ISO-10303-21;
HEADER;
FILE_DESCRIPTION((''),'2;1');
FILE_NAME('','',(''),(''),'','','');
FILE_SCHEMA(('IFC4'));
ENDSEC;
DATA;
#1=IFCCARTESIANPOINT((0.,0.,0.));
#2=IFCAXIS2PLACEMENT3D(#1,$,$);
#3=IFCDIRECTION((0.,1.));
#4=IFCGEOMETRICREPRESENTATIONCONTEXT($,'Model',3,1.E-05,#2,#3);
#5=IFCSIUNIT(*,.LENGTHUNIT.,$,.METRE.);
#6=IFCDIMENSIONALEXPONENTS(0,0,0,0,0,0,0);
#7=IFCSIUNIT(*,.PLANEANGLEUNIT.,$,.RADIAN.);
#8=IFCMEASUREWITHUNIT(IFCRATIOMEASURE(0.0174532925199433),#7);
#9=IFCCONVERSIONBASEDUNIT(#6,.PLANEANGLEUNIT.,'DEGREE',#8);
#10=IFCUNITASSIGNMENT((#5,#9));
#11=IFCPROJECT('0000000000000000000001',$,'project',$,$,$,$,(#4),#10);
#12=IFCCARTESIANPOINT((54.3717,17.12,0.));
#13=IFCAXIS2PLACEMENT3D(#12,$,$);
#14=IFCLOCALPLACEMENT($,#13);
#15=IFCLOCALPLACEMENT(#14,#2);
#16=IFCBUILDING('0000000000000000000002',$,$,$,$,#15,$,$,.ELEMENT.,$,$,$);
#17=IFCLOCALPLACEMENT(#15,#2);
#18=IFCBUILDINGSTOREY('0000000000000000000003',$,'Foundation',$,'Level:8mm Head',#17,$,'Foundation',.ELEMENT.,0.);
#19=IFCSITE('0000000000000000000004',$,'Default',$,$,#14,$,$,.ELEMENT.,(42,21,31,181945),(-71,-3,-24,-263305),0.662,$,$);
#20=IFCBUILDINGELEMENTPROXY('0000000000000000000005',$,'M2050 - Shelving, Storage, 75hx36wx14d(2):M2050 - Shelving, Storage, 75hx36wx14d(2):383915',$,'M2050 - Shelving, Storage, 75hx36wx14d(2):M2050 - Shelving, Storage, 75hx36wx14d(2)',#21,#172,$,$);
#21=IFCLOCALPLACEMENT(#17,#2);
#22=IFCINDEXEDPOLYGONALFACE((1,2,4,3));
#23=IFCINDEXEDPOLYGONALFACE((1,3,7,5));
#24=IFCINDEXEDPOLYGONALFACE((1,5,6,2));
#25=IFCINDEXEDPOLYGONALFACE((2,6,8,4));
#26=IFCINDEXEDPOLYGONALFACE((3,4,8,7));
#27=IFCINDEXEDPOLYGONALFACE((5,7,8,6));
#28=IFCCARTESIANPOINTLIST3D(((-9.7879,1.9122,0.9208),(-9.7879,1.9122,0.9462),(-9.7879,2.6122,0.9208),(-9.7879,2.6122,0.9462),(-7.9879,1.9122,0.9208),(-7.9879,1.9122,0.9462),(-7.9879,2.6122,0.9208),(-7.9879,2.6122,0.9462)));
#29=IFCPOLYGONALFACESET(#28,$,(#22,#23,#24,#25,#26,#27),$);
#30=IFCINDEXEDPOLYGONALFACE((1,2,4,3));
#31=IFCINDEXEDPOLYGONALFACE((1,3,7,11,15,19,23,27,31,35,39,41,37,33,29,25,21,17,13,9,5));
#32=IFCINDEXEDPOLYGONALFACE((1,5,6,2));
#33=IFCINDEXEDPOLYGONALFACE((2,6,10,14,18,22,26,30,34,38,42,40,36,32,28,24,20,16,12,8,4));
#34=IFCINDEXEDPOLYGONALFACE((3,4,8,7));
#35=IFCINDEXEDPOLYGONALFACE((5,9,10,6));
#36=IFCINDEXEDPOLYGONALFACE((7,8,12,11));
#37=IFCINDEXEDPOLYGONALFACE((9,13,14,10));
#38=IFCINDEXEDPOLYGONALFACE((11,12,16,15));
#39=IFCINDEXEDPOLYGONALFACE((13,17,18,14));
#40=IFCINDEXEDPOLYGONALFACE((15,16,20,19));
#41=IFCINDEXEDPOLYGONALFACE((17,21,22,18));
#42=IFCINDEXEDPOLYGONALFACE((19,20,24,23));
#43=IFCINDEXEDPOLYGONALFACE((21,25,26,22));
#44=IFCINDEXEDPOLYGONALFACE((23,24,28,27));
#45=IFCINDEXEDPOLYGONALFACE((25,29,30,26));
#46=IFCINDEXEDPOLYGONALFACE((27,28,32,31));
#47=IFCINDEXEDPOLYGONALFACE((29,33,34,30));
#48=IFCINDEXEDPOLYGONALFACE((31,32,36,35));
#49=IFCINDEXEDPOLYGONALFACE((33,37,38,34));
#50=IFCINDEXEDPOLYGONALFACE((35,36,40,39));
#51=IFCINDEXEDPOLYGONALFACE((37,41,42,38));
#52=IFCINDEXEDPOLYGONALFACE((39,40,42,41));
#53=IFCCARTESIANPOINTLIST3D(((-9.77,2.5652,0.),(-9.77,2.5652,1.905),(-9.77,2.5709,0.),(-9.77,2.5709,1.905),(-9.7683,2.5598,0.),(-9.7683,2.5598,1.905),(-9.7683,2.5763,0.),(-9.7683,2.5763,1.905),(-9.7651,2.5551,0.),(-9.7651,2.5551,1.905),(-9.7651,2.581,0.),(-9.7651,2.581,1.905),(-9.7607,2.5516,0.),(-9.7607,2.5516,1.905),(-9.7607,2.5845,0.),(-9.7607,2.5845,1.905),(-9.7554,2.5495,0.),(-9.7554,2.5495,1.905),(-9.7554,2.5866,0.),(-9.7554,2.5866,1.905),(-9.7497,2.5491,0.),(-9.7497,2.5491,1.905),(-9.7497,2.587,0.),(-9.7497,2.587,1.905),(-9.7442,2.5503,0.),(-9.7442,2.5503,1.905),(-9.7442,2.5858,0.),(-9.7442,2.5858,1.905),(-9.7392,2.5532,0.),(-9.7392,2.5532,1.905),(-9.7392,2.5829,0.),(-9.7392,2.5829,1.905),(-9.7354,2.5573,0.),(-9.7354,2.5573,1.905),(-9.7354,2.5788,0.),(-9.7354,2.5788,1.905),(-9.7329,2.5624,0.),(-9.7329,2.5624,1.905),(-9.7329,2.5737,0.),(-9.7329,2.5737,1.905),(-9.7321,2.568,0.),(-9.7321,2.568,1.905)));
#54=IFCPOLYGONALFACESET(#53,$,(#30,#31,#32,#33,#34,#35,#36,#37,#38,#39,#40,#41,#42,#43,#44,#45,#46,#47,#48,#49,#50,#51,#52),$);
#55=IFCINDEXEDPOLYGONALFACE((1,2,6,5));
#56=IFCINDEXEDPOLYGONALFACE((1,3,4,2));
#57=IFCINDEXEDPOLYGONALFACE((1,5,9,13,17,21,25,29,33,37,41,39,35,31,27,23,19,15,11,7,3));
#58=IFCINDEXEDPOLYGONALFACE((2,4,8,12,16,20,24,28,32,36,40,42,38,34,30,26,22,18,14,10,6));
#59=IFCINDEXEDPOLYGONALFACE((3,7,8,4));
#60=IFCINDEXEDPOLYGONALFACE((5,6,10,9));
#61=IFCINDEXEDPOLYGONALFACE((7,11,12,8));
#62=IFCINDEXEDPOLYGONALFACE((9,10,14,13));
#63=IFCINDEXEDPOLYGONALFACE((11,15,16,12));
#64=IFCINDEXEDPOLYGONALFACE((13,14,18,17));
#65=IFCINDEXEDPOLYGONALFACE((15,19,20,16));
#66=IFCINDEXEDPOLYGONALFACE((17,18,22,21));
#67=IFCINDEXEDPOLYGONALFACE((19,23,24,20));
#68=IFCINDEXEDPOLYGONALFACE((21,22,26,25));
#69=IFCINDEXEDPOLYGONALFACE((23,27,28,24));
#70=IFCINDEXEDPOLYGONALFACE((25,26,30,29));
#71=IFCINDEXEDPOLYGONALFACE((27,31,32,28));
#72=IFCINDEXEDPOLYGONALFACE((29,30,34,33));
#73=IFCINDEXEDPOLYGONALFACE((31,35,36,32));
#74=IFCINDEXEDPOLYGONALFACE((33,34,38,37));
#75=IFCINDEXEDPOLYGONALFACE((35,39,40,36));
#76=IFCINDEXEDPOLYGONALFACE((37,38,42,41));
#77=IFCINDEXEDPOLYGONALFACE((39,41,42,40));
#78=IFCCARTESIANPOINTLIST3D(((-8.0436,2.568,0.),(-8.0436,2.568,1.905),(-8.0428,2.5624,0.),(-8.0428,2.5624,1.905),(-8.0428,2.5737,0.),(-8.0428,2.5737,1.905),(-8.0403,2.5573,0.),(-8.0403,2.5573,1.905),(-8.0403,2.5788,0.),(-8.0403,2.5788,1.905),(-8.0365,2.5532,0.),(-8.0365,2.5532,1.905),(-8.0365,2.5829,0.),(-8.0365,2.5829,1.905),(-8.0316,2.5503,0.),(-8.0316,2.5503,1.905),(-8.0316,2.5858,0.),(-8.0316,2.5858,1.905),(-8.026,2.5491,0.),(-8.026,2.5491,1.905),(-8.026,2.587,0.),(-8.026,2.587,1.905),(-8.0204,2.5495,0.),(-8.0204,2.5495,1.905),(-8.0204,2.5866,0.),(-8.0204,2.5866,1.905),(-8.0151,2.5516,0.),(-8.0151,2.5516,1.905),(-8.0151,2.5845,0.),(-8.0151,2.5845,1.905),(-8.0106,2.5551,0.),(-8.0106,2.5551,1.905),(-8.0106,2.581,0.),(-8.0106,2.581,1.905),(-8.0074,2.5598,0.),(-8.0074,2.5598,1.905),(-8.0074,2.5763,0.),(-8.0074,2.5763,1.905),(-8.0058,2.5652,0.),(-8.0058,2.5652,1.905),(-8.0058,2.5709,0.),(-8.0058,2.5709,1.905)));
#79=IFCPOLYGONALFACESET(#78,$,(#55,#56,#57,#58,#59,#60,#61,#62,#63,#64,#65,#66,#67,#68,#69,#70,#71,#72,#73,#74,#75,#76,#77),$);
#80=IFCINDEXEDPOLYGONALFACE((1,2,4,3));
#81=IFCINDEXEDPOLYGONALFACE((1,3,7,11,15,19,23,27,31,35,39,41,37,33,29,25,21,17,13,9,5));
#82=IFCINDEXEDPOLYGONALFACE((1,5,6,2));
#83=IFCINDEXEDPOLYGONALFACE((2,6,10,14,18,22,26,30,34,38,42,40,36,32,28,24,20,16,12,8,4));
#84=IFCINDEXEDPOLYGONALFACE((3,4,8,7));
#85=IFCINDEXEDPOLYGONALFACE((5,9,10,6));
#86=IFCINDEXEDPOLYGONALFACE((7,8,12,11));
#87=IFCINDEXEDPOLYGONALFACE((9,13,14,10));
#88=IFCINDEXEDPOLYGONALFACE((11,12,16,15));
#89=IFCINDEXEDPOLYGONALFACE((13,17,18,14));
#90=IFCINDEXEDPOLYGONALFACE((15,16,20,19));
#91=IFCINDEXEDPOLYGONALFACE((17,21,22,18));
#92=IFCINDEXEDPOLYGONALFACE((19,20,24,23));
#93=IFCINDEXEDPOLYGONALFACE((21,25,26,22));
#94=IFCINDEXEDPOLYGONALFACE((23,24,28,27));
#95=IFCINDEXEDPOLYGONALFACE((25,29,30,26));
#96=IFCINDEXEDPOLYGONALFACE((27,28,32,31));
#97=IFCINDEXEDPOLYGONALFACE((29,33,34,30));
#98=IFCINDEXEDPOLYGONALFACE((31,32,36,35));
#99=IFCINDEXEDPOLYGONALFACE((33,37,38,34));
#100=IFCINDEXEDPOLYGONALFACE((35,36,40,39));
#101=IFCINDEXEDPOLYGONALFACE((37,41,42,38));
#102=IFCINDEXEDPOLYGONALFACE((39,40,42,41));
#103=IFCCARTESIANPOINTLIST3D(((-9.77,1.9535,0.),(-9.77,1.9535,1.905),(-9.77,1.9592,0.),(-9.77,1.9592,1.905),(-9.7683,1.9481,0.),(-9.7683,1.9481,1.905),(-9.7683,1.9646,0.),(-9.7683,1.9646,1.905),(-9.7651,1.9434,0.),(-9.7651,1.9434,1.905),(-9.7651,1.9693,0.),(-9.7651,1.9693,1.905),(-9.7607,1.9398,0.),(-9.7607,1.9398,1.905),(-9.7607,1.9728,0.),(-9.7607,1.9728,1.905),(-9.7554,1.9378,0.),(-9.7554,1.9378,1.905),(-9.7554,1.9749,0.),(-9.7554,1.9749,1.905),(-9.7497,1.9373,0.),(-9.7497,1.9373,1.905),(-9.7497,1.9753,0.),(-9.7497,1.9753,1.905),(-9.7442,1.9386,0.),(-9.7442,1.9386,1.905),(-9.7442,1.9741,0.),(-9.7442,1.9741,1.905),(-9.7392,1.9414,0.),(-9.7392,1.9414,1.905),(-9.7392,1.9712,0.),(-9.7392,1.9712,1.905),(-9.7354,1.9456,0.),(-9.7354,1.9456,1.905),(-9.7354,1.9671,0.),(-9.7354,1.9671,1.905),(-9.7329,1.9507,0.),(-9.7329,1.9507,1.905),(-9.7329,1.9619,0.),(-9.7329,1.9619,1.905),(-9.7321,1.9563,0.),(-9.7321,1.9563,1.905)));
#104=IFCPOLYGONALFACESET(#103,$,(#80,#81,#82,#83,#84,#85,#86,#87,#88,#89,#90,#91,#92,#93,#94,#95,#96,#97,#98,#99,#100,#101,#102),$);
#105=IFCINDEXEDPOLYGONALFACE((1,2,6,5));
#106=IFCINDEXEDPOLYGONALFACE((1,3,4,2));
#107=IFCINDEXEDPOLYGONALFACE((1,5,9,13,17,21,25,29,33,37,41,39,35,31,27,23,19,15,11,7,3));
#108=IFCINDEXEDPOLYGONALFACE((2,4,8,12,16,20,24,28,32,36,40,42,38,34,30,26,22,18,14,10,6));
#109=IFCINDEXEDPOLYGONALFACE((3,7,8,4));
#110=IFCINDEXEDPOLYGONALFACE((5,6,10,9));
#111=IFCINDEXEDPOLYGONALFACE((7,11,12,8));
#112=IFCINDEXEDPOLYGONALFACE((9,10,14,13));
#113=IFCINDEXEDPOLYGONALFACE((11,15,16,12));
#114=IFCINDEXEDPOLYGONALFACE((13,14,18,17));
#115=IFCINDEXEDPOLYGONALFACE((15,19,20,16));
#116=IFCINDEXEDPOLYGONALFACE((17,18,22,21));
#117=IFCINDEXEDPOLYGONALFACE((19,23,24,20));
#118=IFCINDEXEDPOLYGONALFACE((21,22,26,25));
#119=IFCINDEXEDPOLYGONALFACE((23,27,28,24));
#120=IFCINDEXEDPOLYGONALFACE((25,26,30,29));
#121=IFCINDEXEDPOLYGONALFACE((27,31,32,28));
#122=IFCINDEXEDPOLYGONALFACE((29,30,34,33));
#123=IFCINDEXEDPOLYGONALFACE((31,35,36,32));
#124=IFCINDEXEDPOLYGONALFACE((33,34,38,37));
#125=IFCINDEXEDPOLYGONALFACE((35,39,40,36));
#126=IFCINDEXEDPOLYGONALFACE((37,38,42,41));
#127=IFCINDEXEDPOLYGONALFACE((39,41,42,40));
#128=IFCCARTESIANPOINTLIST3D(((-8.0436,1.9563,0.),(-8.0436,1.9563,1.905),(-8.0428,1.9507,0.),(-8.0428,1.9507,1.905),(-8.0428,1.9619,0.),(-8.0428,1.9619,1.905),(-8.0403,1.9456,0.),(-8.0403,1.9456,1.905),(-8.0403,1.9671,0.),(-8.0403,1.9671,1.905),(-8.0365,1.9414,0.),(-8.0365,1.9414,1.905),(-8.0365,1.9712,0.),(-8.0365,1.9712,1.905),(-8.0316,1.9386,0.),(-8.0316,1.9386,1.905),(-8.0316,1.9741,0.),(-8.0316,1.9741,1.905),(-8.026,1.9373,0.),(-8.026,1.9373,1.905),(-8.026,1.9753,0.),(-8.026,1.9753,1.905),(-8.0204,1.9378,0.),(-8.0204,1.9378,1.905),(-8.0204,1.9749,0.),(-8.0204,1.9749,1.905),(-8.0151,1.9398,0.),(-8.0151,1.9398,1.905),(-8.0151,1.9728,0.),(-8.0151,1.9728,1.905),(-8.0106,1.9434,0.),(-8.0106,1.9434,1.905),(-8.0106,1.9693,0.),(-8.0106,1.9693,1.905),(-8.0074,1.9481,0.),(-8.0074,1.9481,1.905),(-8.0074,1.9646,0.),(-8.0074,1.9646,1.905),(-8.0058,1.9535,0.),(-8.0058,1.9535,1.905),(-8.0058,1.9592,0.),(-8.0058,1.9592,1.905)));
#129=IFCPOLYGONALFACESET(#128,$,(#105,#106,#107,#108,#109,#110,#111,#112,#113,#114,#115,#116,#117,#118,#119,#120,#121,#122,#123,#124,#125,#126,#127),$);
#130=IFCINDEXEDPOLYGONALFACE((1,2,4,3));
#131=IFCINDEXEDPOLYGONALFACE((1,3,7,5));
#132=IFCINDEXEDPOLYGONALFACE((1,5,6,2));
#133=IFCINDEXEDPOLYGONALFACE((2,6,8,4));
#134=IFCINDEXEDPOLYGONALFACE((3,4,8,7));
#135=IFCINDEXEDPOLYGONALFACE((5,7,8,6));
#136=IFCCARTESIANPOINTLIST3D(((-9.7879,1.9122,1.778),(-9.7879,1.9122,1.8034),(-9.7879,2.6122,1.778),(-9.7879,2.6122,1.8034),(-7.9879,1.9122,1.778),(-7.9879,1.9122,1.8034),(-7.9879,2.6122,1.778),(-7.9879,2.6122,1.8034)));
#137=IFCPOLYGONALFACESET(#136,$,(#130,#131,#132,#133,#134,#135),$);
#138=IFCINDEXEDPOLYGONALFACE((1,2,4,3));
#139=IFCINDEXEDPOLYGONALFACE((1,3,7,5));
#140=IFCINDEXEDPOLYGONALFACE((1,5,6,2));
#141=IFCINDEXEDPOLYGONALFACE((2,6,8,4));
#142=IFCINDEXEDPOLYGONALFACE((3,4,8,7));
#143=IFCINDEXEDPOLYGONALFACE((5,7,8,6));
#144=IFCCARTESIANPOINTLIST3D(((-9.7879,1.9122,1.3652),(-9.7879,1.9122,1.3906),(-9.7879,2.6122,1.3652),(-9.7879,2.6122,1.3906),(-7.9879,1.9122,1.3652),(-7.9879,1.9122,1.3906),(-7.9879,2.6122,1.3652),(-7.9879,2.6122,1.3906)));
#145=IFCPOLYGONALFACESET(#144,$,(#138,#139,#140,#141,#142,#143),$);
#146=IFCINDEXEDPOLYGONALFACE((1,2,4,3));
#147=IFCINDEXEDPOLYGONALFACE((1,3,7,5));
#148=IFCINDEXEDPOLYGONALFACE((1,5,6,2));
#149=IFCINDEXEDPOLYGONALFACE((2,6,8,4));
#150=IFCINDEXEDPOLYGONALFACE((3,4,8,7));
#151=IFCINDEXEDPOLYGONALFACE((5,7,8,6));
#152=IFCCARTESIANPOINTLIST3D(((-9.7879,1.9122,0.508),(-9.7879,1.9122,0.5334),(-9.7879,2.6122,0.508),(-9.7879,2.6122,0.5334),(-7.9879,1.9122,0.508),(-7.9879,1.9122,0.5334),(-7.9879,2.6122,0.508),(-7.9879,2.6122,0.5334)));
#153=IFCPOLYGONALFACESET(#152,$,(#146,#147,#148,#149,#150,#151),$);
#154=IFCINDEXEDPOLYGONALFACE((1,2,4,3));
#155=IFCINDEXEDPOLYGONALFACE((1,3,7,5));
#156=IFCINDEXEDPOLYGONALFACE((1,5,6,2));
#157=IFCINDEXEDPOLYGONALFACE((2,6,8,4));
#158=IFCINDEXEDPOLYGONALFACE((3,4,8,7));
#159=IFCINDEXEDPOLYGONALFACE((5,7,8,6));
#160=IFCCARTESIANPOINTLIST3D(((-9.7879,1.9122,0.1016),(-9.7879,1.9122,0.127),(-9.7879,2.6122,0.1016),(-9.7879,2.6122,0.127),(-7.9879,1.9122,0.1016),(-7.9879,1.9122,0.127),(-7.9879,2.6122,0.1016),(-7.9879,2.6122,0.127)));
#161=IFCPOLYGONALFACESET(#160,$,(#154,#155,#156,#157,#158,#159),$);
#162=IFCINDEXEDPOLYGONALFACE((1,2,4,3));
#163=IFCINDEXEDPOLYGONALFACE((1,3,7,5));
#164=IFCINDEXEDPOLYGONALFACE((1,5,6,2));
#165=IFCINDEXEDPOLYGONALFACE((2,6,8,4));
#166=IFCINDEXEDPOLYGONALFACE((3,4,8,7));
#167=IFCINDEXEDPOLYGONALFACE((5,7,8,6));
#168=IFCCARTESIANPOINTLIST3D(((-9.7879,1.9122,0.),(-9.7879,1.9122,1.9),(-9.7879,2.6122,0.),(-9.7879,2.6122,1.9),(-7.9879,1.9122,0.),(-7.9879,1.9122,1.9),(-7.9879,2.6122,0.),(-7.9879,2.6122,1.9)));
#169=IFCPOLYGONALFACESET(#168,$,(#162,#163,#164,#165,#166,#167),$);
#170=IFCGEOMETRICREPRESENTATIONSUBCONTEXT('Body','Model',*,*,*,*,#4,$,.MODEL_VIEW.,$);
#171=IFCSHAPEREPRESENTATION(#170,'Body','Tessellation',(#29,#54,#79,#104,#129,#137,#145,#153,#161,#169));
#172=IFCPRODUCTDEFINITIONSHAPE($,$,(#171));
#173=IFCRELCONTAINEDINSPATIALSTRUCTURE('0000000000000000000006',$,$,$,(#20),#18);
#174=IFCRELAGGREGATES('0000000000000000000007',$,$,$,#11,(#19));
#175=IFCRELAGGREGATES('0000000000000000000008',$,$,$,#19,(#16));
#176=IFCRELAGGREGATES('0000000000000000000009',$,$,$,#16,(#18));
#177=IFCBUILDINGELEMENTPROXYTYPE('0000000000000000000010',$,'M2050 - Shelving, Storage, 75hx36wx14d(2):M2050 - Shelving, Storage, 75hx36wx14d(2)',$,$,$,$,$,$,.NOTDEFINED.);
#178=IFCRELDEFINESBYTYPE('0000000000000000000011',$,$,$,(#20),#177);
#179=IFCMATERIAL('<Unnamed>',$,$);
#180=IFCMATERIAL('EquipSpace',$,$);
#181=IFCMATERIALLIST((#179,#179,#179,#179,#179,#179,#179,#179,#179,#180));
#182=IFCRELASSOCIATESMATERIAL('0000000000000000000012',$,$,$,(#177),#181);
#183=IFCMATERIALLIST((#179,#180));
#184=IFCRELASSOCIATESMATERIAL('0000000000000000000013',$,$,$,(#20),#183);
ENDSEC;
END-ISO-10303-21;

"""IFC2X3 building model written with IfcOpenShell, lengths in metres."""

from ifc_helpers import new_model, entity, si_unit, converted_unit, direction, frame, frame_2d, origin, origin_2d_with_axis, place, context, subcontext, project, spatial, rectangle, circle, extrude, source, transform, mapped, material, material_list, type_object, type_shapes, element, save


model = new_model("IFC2X3")

# Units and contexts
model_context = context("Model", 3, precision=1e-05, world=origin(), true_north=direction((0.0, 1.0)))
body_context = subcontext(model_context, "Body", "Model", "MODEL_VIEW")
ifc_project = project(units=[si_unit("LENGTHUNIT", "METRE"), converted_unit("PLANEANGLEUNIT", "DEGREE", entity("IfcRatioMeasure", 0.0174532925199433), si_unit("PLANEANGLEUNIT", "RADIAN"), dimensions=[0, 0, 0, 0, 0, 0, 0])], contexts=[model_context])

# Site, building, storey
site_placement = place(None, frame((54.3717, 17.12, 0.0)))
site = spatial("IfcSite", under=ifc_project, at=site_placement, Name="Default", CompositionType="ELEMENT", RefLatitude=(42, 21, 31, 181945), RefLongitude=(-71, -3, -24, -263305), RefElevation=0.662)
building_placement = place(site_placement, origin())
building = spatial("IfcBuilding", under=site, at=building_placement, CompositionType="ELEMENT")
storey_placement = place(building_placement, origin())
storey = spatial("IfcBuildingStorey", under=building, at=storey_placement, Name="Foundation", ObjectType="Level:8mm Head", LongName="Foundation", CompositionType="ELEMENT", Elevation=0.0)

# Building element proxy
ifc_material_1 = material(Name="<Unnamed>")
ifc_material_2 = material(Name="EquipSpace")
ifc_material_list_1 = material_list([ifc_material_1, ifc_material_1, ifc_material_1, ifc_material_1, ifc_material_1, ifc_material_1, ifc_material_1, ifc_material_1, ifc_material_1, ifc_material_2])
building_element_proxy_type = type_object("IfcBuildingElementProxyType", Name="M2050 - Shelving, Storage, 75hx36wx14d(2):M2050 - Shelving, Storage, 75hx36wx14d(2)", PredefinedType="NOTDEFINED", material=ifc_material_list_1)
shared_shape = source(origin(), body_context, "Body", "SweptSolid", [
    extrude(rectangle(XDim=1.8, YDim=0.7, at=origin_2d_with_axis()), frame((0.0, 0.0, 0.9207), z_axis=(0.0, 0.0, 1.0), x_axis=(-1.0, 0.0, 0.0)), (0.0, 0.0, 1.0), 0.0254),
    extrude(circle(Radius=0.0191, at=origin_2d_with_axis()), frame((0.8633, -0.3059, 0.0), z_axis=(0.0, 0.0, 1.0), x_axis=(-1.0, 0.0, 0.0)), (0.0, 0.0, 1.0), 1.905),
    extrude(circle(Radius=0.0191, at=origin_2d_with_axis()), frame((-0.8633, -0.3059, 0.0)), (0.0, 0.0, 1.0), 1.905),
    extrude(circle(Radius=0.0191, at=origin_2d_with_axis()), frame((0.8633, 0.3059, 0.0), z_axis=(0.0, 0.0, 1.0), x_axis=(-1.0, 0.0, 0.0)), (0.0, 0.0, 1.0), 1.905),
    extrude(circle(Radius=0.0191, at=origin_2d_with_axis()), frame((-0.8633, 0.3059, 0.0)), (0.0, 0.0, 1.0), 1.905),
    extrude(rectangle(XDim=1.8, YDim=0.7, at=origin_2d_with_axis()), frame((0.0, 0.0, 1.778), z_axis=(0.0, 0.0, 1.0), x_axis=(-1.0, 0.0, 0.0)), (0.0, 0.0, 1.0), 0.0254),
    extrude(rectangle(XDim=1.8, YDim=0.7, at=origin_2d_with_axis()), frame((0.0, 0.0, 1.3653), z_axis=(0.0, 0.0, 1.0), x_axis=(-1.0, 0.0, 0.0)), (0.0, 0.0, 1.0), 0.0254),
    extrude(rectangle(XDim=1.8, YDim=0.7, at=origin_2d_with_axis()), frame((0.0, 0.0, 0.508), z_axis=(0.0, 0.0, 1.0), x_axis=(-1.0, 0.0, 0.0)), (0.0, 0.0, 1.0), 0.0254),
    extrude(rectangle(XDim=1.8, YDim=0.7, at=origin_2d_with_axis()), frame((0.0, 0.0, 0.1016), z_axis=(0.0, 0.0, 1.0), x_axis=(-1.0, 0.0, 0.0)), (0.0, 0.0, 1.0), 0.0254),
    extrude(rectangle(XDim=0.7, YDim=1.8, at=frame_2d((0.0, 0.18), x_axis=(1.0, 0.0))), frame((-0.18, 0.0, 0.0), z_axis=(0.0, 0.0, 1.0), x_axis=(0.0, -1.0, 0.0)), (0.0, 0.0, 1.0), 1.9),
])
type_shapes(building_element_proxy_type, [shared_shape])
ifc_material_list_2 = material_list([ifc_material_1, ifc_material_2])
proxy_1_placement = place(storey_placement, frame((-8.8879, 2.2622, 0.0), z_axis=(0.0, 0.0, 1.0), x_axis=(-1.0, 0.0, 0.0)))
element("IfcBuildingElementProxy", 1, at=proxy_1_placement, inside=storey, type_object=building_element_proxy_type, material=ifc_material_list_2, Name="M2050 - Shelving, Storage, 75hx36wx14d(2):M2050 - Shelving, Storage, 75hx36wx14d(2):383915", ObjectType="M2050 - Shelving, Storage, 75hx36wx14d(2):M2050 - Shelving, Storage, 75hx36wx14d(2)", context=body_context, shape_type="MappedRepresentation", body=[
    mapped(shared_shape, transform((0.0, 0.0, 0.0), scale=1.0)),
])

save(model, "model.ifc")
